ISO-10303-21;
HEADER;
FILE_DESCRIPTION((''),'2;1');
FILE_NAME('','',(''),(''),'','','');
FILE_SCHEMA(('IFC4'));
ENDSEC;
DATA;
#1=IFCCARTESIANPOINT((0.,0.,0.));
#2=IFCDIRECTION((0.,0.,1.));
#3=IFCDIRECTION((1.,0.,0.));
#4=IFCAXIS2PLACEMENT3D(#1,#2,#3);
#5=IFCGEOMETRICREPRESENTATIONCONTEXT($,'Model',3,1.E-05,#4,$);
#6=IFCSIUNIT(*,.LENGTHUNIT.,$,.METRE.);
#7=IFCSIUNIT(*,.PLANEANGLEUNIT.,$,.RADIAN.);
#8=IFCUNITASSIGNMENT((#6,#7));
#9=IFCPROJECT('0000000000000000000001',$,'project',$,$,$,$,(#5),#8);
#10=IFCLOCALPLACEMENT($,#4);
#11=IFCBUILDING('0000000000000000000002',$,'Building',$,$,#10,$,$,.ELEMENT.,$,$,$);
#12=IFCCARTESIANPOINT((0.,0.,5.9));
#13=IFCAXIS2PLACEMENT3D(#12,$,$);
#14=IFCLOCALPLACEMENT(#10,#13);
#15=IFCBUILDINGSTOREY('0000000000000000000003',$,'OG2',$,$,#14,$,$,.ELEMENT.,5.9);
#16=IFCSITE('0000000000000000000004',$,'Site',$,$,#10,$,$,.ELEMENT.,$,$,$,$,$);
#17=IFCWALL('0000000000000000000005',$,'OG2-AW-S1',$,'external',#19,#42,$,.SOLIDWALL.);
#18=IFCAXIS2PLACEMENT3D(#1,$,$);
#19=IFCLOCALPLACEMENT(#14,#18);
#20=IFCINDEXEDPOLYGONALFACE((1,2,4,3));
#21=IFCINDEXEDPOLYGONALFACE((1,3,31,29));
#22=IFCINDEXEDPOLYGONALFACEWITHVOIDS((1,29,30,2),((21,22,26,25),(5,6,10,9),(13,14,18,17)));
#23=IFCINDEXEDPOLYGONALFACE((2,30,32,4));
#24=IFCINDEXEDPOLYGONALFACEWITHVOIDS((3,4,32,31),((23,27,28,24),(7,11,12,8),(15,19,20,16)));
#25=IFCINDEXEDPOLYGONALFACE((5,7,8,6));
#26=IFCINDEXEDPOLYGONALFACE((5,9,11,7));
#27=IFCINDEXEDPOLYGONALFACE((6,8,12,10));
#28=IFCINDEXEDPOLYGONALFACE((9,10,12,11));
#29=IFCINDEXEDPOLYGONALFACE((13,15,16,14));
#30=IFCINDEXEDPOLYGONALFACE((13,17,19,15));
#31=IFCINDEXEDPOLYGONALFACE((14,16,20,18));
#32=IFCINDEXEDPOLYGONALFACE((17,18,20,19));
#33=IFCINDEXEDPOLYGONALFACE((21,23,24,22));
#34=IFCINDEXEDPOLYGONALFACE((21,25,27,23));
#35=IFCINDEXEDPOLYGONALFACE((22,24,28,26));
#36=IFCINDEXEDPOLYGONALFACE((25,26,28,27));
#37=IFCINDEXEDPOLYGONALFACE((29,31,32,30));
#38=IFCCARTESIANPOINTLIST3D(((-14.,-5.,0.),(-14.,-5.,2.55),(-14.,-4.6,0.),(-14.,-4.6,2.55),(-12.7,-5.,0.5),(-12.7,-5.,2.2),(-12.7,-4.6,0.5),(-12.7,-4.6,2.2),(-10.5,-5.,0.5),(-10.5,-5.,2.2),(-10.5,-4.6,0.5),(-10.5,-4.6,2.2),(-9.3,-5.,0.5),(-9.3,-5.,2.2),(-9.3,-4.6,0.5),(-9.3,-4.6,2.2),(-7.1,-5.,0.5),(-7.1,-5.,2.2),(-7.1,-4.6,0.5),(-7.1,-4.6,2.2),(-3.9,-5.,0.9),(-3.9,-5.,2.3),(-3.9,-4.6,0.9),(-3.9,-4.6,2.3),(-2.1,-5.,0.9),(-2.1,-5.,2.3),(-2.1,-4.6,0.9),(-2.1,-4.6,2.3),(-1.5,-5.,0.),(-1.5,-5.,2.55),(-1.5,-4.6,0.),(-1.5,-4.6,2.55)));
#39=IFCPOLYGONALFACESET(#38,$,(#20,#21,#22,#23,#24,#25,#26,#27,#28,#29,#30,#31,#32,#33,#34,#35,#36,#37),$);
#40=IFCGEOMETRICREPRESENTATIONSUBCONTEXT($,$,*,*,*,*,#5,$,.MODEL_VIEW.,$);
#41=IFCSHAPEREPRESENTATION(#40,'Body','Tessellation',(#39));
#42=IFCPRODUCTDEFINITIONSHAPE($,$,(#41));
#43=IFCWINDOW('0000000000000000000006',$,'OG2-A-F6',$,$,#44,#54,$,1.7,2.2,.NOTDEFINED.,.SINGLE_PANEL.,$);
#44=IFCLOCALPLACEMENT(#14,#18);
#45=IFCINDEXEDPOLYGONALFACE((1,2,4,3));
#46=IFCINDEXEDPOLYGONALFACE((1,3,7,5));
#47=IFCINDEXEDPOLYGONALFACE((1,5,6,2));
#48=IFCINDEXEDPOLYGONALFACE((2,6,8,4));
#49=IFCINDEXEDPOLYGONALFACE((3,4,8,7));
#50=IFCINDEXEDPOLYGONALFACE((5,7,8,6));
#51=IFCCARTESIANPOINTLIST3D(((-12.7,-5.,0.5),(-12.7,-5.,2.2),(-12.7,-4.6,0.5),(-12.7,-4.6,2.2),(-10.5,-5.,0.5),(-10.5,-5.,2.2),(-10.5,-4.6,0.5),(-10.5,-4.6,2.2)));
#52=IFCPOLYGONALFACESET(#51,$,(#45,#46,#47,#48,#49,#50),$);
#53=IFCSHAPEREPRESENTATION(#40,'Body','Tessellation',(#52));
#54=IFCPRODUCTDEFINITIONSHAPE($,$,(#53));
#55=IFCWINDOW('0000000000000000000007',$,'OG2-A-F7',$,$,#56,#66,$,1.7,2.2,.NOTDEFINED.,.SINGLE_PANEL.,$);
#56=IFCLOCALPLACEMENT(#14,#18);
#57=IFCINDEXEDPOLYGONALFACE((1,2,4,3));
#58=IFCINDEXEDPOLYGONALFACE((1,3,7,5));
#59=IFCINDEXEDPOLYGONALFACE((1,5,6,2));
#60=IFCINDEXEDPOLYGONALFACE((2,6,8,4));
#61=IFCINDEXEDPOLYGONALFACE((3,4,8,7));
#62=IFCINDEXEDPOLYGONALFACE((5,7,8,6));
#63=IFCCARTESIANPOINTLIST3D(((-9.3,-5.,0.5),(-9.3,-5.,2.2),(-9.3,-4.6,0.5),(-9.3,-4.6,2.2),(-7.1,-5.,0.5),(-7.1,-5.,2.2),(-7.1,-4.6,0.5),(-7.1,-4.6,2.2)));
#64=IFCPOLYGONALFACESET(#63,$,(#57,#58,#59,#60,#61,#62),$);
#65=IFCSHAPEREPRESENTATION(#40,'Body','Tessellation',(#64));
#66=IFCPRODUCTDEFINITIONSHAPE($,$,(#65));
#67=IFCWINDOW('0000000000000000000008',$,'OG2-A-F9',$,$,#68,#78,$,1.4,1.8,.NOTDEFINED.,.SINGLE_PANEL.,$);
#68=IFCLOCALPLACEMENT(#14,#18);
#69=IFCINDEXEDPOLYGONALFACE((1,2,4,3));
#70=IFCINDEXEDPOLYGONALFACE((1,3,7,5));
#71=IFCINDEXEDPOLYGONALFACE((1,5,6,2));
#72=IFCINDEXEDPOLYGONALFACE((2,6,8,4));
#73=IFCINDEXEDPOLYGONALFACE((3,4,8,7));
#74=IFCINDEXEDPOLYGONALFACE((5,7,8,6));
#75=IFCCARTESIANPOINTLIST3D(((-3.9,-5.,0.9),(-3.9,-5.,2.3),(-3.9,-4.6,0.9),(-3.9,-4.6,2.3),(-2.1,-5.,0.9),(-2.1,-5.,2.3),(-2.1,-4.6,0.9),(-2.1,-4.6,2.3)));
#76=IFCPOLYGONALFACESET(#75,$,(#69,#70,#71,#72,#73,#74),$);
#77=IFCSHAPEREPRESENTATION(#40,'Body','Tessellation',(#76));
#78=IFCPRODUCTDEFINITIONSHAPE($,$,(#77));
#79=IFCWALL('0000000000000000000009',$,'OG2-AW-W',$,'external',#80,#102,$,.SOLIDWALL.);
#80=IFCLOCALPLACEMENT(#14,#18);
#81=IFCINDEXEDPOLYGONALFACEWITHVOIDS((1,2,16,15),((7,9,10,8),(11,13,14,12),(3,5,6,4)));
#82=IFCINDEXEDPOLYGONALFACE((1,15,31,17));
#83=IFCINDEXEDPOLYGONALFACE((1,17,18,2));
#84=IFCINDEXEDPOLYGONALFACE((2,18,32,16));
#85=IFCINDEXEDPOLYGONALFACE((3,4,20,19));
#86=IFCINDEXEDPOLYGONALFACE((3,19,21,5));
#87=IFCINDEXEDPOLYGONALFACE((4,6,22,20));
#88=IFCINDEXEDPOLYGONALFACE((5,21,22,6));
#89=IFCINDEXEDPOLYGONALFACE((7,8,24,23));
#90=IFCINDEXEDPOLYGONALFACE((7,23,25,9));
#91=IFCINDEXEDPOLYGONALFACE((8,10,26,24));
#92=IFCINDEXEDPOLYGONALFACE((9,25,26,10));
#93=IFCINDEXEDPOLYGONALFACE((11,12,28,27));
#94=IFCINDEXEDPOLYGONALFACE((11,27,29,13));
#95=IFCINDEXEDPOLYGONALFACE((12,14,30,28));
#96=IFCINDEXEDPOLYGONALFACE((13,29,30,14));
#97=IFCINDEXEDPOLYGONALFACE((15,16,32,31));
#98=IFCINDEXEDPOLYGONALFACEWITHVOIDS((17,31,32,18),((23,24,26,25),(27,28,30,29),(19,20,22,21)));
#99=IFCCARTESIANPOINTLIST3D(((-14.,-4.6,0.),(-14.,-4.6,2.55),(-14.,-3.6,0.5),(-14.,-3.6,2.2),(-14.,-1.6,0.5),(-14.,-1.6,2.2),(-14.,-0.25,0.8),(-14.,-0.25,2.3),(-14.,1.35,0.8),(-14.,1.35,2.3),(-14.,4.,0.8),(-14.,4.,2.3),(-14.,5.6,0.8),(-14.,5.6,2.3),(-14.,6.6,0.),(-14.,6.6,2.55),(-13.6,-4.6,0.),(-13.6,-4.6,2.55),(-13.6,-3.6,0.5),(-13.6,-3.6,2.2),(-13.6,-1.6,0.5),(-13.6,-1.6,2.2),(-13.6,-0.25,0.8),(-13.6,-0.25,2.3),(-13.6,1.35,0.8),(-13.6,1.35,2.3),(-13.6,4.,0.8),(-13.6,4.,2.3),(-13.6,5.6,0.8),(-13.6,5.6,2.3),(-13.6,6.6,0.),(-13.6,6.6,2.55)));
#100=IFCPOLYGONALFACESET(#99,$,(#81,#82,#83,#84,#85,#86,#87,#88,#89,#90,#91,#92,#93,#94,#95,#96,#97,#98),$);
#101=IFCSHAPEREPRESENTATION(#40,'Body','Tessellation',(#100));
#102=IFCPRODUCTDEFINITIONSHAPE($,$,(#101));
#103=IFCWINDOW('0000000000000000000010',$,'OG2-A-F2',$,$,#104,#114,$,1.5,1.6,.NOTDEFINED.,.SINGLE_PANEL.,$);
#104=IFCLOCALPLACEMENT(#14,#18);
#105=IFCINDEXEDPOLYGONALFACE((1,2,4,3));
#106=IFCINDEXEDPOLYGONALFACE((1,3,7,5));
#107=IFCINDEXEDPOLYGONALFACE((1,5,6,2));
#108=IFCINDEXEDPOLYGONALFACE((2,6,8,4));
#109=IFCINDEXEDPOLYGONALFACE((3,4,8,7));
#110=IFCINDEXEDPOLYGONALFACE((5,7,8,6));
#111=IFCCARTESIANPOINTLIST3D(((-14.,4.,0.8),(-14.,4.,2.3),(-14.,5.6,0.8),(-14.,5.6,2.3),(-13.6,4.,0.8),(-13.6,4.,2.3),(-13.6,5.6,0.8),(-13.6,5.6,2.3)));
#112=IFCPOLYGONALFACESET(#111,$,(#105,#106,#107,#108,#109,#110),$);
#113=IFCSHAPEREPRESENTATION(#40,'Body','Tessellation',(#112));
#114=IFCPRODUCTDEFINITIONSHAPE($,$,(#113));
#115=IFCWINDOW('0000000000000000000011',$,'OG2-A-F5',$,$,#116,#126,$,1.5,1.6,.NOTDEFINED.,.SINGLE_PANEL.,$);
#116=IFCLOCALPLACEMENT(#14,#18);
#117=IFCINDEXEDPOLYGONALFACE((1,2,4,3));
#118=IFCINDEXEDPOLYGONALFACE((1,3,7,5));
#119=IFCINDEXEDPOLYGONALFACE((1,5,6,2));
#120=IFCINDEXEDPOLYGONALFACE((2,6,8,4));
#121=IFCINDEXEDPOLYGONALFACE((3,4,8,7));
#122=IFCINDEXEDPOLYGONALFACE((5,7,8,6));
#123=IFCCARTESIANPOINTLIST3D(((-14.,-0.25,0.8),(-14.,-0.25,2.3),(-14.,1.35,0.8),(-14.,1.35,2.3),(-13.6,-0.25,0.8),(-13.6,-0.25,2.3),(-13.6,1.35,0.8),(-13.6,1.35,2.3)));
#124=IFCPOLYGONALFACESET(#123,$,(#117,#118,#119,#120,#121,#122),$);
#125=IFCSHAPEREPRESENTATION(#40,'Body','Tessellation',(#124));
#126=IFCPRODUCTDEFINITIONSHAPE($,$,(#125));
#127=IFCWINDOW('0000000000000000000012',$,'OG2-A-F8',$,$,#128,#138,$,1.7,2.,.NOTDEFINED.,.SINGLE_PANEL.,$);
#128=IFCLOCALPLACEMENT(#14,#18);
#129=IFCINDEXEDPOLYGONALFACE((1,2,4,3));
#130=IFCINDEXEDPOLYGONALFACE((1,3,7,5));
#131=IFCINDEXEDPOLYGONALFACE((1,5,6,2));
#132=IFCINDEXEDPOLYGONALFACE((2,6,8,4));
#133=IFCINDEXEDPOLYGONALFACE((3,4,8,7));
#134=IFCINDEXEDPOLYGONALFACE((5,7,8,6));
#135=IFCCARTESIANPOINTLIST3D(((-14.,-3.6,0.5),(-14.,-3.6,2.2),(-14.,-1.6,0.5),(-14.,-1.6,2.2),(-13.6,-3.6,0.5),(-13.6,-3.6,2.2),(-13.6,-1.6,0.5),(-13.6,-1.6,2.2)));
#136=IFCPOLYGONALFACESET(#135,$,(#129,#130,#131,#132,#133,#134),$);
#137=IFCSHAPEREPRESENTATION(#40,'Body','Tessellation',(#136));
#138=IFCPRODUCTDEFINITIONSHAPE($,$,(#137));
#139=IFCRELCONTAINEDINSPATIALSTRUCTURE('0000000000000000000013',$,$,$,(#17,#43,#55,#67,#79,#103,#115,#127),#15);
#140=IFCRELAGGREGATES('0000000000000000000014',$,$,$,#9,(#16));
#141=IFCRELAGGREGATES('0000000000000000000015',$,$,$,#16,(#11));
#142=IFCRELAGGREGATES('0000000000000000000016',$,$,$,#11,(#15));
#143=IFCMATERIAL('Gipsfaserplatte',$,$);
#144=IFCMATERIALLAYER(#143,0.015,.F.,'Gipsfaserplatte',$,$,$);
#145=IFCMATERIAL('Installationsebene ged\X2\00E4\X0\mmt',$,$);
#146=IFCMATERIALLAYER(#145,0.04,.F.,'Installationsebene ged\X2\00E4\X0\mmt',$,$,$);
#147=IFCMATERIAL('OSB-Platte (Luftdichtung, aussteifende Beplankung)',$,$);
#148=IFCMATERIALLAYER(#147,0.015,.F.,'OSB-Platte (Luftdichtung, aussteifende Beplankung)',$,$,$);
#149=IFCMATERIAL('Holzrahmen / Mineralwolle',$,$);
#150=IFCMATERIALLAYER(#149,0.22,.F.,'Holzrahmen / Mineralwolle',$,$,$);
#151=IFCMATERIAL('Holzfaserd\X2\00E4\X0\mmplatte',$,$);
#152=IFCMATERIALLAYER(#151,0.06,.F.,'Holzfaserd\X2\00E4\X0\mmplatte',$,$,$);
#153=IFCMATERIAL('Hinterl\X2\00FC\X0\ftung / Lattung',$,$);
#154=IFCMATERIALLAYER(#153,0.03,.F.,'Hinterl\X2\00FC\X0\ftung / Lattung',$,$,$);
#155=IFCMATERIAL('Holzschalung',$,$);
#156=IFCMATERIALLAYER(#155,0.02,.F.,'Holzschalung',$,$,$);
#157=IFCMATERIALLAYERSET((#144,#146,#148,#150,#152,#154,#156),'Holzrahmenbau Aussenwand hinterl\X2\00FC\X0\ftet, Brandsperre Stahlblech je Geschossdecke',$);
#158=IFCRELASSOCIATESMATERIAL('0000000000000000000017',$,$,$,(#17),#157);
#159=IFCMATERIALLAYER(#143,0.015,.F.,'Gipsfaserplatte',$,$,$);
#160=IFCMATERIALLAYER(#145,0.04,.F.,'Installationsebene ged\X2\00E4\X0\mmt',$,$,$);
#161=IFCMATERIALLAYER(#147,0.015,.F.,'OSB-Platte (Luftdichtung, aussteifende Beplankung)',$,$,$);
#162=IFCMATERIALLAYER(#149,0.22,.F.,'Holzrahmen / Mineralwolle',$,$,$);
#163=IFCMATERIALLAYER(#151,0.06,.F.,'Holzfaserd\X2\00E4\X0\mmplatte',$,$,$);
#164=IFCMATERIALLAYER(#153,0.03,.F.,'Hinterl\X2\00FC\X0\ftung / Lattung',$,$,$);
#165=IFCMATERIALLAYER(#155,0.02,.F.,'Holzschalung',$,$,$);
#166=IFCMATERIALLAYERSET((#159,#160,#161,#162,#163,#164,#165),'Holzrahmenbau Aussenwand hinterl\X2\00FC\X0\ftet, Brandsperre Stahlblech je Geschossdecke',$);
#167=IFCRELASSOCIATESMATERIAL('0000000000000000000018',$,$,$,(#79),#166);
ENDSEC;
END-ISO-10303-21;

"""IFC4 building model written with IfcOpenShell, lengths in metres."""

from ifc_helpers import new_model, si_unit, frame, frame_2d, origin, origin_with_axes, place, context, subcontext, project, spatial, rectangle, extrude, material, layer, layer_set, element, fill, save


model = new_model("IFC4")

# Units and contexts
model_context = context("Model", 3, precision=1e-05, world=origin_with_axes())
sub_context = subcontext(model_context, None, None, "MODEL_VIEW")
ifc_project = project(units=[si_unit("LENGTHUNIT", "METRE"), si_unit("PLANEANGLEUNIT", "RADIAN")], contexts=[model_context])

# Site, building, storey
placement = place(None, origin_with_axes())
site = spatial("IfcSite", under=ifc_project, at=placement, Name="Site", CompositionType="ELEMENT")
building = spatial("IfcBuilding", under=site, at=placement, Name="Building", CompositionType="ELEMENT")
storey_placement = place(placement, frame((0.0, 0.0, 5.9)))
storey = spatial("IfcBuildingStorey", under=building, at=storey_placement, Name="OG2", CompositionType="ELEMENT", Elevation=5.9)

# Walls, openings, windows
ifc_material_1 = material(Name="Gipsfaserplatte")
ifc_layer_1 = layer(ifc_material_1, 0.015, ventilated=False, Name="Gipsfaserplatte")
ifc_material_2 = material(Name="Installationsebene gedämmt")
ifc_layer_2 = layer(ifc_material_2, 0.04, ventilated=False, Name="Installationsebene gedämmt")
ifc_material_3 = material(Name="OSB-Platte (Luftdichtung, aussteifende Beplankung)")
ifc_layer_3 = layer(ifc_material_3, 0.015, ventilated=False, Name="OSB-Platte (Luftdichtung, aussteifende Beplankung)")
ifc_material_4 = material(Name="Holzrahmen / Mineralwolle")
ifc_layer_4 = layer(ifc_material_4, 0.22, ventilated=False, Name="Holzrahmen / Mineralwolle")
ifc_material_5 = material(Name="Holzfaserdämmplatte")
ifc_layer_5 = layer(ifc_material_5, 0.06, ventilated=False, Name="Holzfaserdämmplatte")
ifc_material_6 = material(Name="Hinterlüftung / Lattung")
ifc_layer_6 = layer(ifc_material_6, 0.03, ventilated=False, Name="Hinterlüftung / Lattung")
ifc_material_7 = material(Name="Holzschalung")
ifc_layer_7 = layer(ifc_material_7, 0.02, ventilated=False, Name="Holzschalung")
ifc_layer_set_1 = layer_set([ifc_layer_1, ifc_layer_2, ifc_layer_3, ifc_layer_4, ifc_layer_5, ifc_layer_6, ifc_layer_7], Name="Holzrahmenbau Aussenwand hinterlüftet, Brandsperre Stahlblech je Geschossdecke")
wall_1_placement = place(storey_placement, frame((-14.0, -4.8, 0.0), z_axis=(0.0, 0.0, 1.0), x_axis=(1.0, 0.0, 0.0)))
wall_1 = element("IfcWall", 1, at=wall_1_placement, inside=storey, material=ifc_layer_set_1, Name="OG2-AW-S1", ObjectType="external", PredefinedType="SOLIDWALL", context=sub_context, shape_type="SweptSolid", body=[
    extrude(rectangle(XDim=12.5, YDim=0.4, at=frame_2d((6.25, 0.0))), origin(), (0.0, 0.0, 1.0), 2.55),
])
opening_1_placement = place(wall_1_placement, frame((2.4, 0.25, 0.5), z_axis=(0.0, -1.0, 0.0), x_axis=(1.0, 0.0, 0.0)))
opening_1 = element("IfcOpeningElement", 2, at=opening_1_placement, cuts=wall_1, PredefinedType="OPENING", context=sub_context, shape_type="SweptSolid", body=[
    extrude(rectangle(XDim=2.2, YDim=1.7, at=frame_2d((0.0, 0.85))), origin(), (0.0, 0.0, 1.0), 0.5),
])
opening_2_placement = place(wall_1_placement, frame((5.8, 0.25, 0.5), z_axis=(0.0, -1.0, 0.0), x_axis=(1.0, 0.0, 0.0)))
opening_2 = element("IfcOpeningElement", 3, at=opening_2_placement, cuts=wall_1, PredefinedType="OPENING", context=sub_context, shape_type="SweptSolid", body=[
    extrude(rectangle(XDim=2.2, YDim=1.7, at=frame_2d((0.0, 0.85))), origin(), (0.0, 0.0, 1.0), 0.5),
])
opening_3_placement = place(wall_1_placement, frame((11.0, 0.25, 0.9), z_axis=(0.0, -1.0, 0.0), x_axis=(1.0, 0.0, 0.0)))
opening_3 = element("IfcOpeningElement", 4, at=opening_3_placement, cuts=wall_1, PredefinedType="OPENING", context=sub_context, shape_type="SweptSolid", body=[
    extrude(rectangle(XDim=1.8, YDim=1.4, at=frame_2d((0.0, 0.7))), origin(), (0.0, 0.0, 1.0), 0.5),
])
window_1_placement = place(wall_1_placement, frame((2.4, 0.2, 0.5), z_axis=(0.0, -1.0, 0.0), x_axis=(1.0, 0.0, 0.0)))
window_1 = element("IfcWindow", 5, at=window_1_placement, inside=storey, Name="OG2-A-F6", OverallHeight=1.7, OverallWidth=2.2, PartitioningType="SINGLE_PANEL", PredefinedType="NOTDEFINED", context=sub_context, shape_type="SweptSolid", body=[
    extrude(rectangle(XDim=2.2, YDim=1.7, at=frame_2d((0.0, 0.85))), origin(), (0.0, 0.0, 1.0), 0.4),
])
fill(opening_1, window_1)
window_2_placement = place(wall_1_placement, frame((5.8, 0.2, 0.5), z_axis=(0.0, -1.0, 0.0), x_axis=(1.0, 0.0, 0.0)))
window_2 = element("IfcWindow", 6, at=window_2_placement, inside=storey, Name="OG2-A-F7", OverallHeight=1.7, OverallWidth=2.2, PartitioningType="SINGLE_PANEL", PredefinedType="NOTDEFINED", context=sub_context, shape_type="SweptSolid", body=[
    extrude(rectangle(XDim=2.2, YDim=1.7, at=frame_2d((0.0, 0.85))), origin(), (0.0, 0.0, 1.0), 0.4),
])
fill(opening_2, window_2)
window_3_placement = place(wall_1_placement, frame((11.0, 0.2, 0.9), z_axis=(0.0, -1.0, 0.0), x_axis=(1.0, 0.0, 0.0)))
window_3 = element("IfcWindow", 7, at=window_3_placement, inside=storey, Name="OG2-A-F9", OverallHeight=1.4, OverallWidth=1.8, PartitioningType="SINGLE_PANEL", PredefinedType="NOTDEFINED", context=sub_context, shape_type="SweptSolid", body=[
    extrude(rectangle(XDim=1.8, YDim=1.4, at=frame_2d((0.0, 0.7))), origin(), (0.0, 0.0, 1.0), 0.4),
])
fill(opening_3, window_3)
ifc_layer_8 = layer(ifc_material_1, 0.015, ventilated=False, Name="Gipsfaserplatte")
ifc_layer_9 = layer(ifc_material_2, 0.04, ventilated=False, Name="Installationsebene gedämmt")
ifc_layer_10 = layer(ifc_material_3, 0.015, ventilated=False, Name="OSB-Platte (Luftdichtung, aussteifende Beplankung)")
ifc_layer_11 = layer(ifc_material_4, 0.22, ventilated=False, Name="Holzrahmen / Mineralwolle")
ifc_layer_12 = layer(ifc_material_5, 0.06, ventilated=False, Name="Holzfaserdämmplatte")
ifc_layer_13 = layer(ifc_material_6, 0.03, ventilated=False, Name="Hinterlüftung / Lattung")
ifc_layer_14 = layer(ifc_material_7, 0.02, ventilated=False, Name="Holzschalung")
ifc_layer_set_2 = layer_set([ifc_layer_8, ifc_layer_9, ifc_layer_10, ifc_layer_11, ifc_layer_12, ifc_layer_13, ifc_layer_14], Name="Holzrahmenbau Aussenwand hinterlüftet, Brandsperre Stahlblech je Geschossdecke")
wall_2_placement = place(storey_placement, frame((-13.8, -4.6, 0.0), z_axis=(0.0, 0.0, 1.0), x_axis=(0.0, 1.0, 0.0)))
wall_2 = element("IfcWall", 8, at=wall_2_placement, inside=storey, material=ifc_layer_set_2, Name="OG2-AW-W", ObjectType="external", PredefinedType="SOLIDWALL", context=sub_context, shape_type="SweptSolid", body=[
    extrude(rectangle(XDim=11.2, YDim=0.4, at=frame_2d((5.6, 0.0))), origin(), (0.0, 0.0, 1.0), 2.55),
])
opening_4_placement = place(wall_2_placement, frame((9.4, 0.25, 0.8), z_axis=(0.0, -1.0, 0.0), x_axis=(1.0, 0.0, 0.0)))
opening_4 = element("IfcOpeningElement", 9, at=opening_4_placement, cuts=wall_2, PredefinedType="OPENING", context=sub_context, shape_type="SweptSolid", body=[
    extrude(rectangle(XDim=1.6, YDim=1.5, at=frame_2d((0.0, 0.75))), origin(), (0.0, 0.0, 1.0), 0.5),
])
opening_5_placement = place(wall_2_placement, frame((5.15, 0.25, 0.8), z_axis=(0.0, -1.0, 0.0), x_axis=(1.0, 0.0, 0.0)))
opening_5 = element("IfcOpeningElement", 10, at=opening_5_placement, cuts=wall_2, PredefinedType="OPENING", context=sub_context, shape_type="SweptSolid", body=[
    extrude(rectangle(XDim=1.6, YDim=1.5, at=frame_2d((0.0, 0.75))), origin(), (0.0, 0.0, 1.0), 0.5),
])
opening_6_placement = place(wall_2_placement, frame((2.0, 0.25, 0.5), z_axis=(0.0, -1.0, 0.0), x_axis=(1.0, 0.0, 0.0)))
opening_6 = element("IfcOpeningElement", 11, at=opening_6_placement, cuts=wall_2, PredefinedType="OPENING", context=sub_context, shape_type="SweptSolid", body=[
    extrude(rectangle(XDim=2.0, YDim=1.7, at=frame_2d((0.0, 0.85))), origin(), (0.0, 0.0, 1.0), 0.5),
])
window_4_placement = place(wall_2_placement, frame((9.4, 0.2, 0.8), z_axis=(0.0, -1.0, 0.0), x_axis=(1.0, 0.0, 0.0)))
window_4 = element("IfcWindow", 12, at=window_4_placement, inside=storey, Name="OG2-A-F2", OverallHeight=1.5, OverallWidth=1.6, PartitioningType="SINGLE_PANEL", PredefinedType="NOTDEFINED", context=sub_context, shape_type="SweptSolid", body=[
    extrude(rectangle(XDim=1.6, YDim=1.5, at=frame_2d((0.0, 0.75))), origin(), (0.0, 0.0, 1.0), 0.4),
])
fill(opening_4, window_4)
window_5_placement = place(wall_2_placement, frame((5.15, 0.2, 0.8), z_axis=(0.0, -1.0, 0.0), x_axis=(1.0, 0.0, 0.0)))
window_5 = element("IfcWindow", 13, at=window_5_placement, inside=storey, Name="OG2-A-F5", OverallHeight=1.5, OverallWidth=1.6, PartitioningType="SINGLE_PANEL", PredefinedType="NOTDEFINED", context=sub_context, shape_type="SweptSolid", body=[
    extrude(rectangle(XDim=1.6, YDim=1.5, at=frame_2d((0.0, 0.75))), origin(), (0.0, 0.0, 1.0), 0.4),
])
fill(opening_5, window_5)
window_6_placement = place(wall_2_placement, frame((2.0, 0.2, 0.5), z_axis=(0.0, -1.0, 0.0), x_axis=(1.0, 0.0, 0.0)))
window_6 = element("IfcWindow", 14, at=window_6_placement, inside=storey, Name="OG2-A-F8", OverallHeight=1.7, OverallWidth=2.0, PartitioningType="SINGLE_PANEL", PredefinedType="NOTDEFINED", context=sub_context, shape_type="SweptSolid", body=[
    extrude(rectangle(XDim=2.0, YDim=1.7, at=frame_2d((0.0, 0.85))), origin(), (0.0, 0.0, 1.0), 0.4),
])
fill(opening_6, window_6)

save(model, "model.ifc")
